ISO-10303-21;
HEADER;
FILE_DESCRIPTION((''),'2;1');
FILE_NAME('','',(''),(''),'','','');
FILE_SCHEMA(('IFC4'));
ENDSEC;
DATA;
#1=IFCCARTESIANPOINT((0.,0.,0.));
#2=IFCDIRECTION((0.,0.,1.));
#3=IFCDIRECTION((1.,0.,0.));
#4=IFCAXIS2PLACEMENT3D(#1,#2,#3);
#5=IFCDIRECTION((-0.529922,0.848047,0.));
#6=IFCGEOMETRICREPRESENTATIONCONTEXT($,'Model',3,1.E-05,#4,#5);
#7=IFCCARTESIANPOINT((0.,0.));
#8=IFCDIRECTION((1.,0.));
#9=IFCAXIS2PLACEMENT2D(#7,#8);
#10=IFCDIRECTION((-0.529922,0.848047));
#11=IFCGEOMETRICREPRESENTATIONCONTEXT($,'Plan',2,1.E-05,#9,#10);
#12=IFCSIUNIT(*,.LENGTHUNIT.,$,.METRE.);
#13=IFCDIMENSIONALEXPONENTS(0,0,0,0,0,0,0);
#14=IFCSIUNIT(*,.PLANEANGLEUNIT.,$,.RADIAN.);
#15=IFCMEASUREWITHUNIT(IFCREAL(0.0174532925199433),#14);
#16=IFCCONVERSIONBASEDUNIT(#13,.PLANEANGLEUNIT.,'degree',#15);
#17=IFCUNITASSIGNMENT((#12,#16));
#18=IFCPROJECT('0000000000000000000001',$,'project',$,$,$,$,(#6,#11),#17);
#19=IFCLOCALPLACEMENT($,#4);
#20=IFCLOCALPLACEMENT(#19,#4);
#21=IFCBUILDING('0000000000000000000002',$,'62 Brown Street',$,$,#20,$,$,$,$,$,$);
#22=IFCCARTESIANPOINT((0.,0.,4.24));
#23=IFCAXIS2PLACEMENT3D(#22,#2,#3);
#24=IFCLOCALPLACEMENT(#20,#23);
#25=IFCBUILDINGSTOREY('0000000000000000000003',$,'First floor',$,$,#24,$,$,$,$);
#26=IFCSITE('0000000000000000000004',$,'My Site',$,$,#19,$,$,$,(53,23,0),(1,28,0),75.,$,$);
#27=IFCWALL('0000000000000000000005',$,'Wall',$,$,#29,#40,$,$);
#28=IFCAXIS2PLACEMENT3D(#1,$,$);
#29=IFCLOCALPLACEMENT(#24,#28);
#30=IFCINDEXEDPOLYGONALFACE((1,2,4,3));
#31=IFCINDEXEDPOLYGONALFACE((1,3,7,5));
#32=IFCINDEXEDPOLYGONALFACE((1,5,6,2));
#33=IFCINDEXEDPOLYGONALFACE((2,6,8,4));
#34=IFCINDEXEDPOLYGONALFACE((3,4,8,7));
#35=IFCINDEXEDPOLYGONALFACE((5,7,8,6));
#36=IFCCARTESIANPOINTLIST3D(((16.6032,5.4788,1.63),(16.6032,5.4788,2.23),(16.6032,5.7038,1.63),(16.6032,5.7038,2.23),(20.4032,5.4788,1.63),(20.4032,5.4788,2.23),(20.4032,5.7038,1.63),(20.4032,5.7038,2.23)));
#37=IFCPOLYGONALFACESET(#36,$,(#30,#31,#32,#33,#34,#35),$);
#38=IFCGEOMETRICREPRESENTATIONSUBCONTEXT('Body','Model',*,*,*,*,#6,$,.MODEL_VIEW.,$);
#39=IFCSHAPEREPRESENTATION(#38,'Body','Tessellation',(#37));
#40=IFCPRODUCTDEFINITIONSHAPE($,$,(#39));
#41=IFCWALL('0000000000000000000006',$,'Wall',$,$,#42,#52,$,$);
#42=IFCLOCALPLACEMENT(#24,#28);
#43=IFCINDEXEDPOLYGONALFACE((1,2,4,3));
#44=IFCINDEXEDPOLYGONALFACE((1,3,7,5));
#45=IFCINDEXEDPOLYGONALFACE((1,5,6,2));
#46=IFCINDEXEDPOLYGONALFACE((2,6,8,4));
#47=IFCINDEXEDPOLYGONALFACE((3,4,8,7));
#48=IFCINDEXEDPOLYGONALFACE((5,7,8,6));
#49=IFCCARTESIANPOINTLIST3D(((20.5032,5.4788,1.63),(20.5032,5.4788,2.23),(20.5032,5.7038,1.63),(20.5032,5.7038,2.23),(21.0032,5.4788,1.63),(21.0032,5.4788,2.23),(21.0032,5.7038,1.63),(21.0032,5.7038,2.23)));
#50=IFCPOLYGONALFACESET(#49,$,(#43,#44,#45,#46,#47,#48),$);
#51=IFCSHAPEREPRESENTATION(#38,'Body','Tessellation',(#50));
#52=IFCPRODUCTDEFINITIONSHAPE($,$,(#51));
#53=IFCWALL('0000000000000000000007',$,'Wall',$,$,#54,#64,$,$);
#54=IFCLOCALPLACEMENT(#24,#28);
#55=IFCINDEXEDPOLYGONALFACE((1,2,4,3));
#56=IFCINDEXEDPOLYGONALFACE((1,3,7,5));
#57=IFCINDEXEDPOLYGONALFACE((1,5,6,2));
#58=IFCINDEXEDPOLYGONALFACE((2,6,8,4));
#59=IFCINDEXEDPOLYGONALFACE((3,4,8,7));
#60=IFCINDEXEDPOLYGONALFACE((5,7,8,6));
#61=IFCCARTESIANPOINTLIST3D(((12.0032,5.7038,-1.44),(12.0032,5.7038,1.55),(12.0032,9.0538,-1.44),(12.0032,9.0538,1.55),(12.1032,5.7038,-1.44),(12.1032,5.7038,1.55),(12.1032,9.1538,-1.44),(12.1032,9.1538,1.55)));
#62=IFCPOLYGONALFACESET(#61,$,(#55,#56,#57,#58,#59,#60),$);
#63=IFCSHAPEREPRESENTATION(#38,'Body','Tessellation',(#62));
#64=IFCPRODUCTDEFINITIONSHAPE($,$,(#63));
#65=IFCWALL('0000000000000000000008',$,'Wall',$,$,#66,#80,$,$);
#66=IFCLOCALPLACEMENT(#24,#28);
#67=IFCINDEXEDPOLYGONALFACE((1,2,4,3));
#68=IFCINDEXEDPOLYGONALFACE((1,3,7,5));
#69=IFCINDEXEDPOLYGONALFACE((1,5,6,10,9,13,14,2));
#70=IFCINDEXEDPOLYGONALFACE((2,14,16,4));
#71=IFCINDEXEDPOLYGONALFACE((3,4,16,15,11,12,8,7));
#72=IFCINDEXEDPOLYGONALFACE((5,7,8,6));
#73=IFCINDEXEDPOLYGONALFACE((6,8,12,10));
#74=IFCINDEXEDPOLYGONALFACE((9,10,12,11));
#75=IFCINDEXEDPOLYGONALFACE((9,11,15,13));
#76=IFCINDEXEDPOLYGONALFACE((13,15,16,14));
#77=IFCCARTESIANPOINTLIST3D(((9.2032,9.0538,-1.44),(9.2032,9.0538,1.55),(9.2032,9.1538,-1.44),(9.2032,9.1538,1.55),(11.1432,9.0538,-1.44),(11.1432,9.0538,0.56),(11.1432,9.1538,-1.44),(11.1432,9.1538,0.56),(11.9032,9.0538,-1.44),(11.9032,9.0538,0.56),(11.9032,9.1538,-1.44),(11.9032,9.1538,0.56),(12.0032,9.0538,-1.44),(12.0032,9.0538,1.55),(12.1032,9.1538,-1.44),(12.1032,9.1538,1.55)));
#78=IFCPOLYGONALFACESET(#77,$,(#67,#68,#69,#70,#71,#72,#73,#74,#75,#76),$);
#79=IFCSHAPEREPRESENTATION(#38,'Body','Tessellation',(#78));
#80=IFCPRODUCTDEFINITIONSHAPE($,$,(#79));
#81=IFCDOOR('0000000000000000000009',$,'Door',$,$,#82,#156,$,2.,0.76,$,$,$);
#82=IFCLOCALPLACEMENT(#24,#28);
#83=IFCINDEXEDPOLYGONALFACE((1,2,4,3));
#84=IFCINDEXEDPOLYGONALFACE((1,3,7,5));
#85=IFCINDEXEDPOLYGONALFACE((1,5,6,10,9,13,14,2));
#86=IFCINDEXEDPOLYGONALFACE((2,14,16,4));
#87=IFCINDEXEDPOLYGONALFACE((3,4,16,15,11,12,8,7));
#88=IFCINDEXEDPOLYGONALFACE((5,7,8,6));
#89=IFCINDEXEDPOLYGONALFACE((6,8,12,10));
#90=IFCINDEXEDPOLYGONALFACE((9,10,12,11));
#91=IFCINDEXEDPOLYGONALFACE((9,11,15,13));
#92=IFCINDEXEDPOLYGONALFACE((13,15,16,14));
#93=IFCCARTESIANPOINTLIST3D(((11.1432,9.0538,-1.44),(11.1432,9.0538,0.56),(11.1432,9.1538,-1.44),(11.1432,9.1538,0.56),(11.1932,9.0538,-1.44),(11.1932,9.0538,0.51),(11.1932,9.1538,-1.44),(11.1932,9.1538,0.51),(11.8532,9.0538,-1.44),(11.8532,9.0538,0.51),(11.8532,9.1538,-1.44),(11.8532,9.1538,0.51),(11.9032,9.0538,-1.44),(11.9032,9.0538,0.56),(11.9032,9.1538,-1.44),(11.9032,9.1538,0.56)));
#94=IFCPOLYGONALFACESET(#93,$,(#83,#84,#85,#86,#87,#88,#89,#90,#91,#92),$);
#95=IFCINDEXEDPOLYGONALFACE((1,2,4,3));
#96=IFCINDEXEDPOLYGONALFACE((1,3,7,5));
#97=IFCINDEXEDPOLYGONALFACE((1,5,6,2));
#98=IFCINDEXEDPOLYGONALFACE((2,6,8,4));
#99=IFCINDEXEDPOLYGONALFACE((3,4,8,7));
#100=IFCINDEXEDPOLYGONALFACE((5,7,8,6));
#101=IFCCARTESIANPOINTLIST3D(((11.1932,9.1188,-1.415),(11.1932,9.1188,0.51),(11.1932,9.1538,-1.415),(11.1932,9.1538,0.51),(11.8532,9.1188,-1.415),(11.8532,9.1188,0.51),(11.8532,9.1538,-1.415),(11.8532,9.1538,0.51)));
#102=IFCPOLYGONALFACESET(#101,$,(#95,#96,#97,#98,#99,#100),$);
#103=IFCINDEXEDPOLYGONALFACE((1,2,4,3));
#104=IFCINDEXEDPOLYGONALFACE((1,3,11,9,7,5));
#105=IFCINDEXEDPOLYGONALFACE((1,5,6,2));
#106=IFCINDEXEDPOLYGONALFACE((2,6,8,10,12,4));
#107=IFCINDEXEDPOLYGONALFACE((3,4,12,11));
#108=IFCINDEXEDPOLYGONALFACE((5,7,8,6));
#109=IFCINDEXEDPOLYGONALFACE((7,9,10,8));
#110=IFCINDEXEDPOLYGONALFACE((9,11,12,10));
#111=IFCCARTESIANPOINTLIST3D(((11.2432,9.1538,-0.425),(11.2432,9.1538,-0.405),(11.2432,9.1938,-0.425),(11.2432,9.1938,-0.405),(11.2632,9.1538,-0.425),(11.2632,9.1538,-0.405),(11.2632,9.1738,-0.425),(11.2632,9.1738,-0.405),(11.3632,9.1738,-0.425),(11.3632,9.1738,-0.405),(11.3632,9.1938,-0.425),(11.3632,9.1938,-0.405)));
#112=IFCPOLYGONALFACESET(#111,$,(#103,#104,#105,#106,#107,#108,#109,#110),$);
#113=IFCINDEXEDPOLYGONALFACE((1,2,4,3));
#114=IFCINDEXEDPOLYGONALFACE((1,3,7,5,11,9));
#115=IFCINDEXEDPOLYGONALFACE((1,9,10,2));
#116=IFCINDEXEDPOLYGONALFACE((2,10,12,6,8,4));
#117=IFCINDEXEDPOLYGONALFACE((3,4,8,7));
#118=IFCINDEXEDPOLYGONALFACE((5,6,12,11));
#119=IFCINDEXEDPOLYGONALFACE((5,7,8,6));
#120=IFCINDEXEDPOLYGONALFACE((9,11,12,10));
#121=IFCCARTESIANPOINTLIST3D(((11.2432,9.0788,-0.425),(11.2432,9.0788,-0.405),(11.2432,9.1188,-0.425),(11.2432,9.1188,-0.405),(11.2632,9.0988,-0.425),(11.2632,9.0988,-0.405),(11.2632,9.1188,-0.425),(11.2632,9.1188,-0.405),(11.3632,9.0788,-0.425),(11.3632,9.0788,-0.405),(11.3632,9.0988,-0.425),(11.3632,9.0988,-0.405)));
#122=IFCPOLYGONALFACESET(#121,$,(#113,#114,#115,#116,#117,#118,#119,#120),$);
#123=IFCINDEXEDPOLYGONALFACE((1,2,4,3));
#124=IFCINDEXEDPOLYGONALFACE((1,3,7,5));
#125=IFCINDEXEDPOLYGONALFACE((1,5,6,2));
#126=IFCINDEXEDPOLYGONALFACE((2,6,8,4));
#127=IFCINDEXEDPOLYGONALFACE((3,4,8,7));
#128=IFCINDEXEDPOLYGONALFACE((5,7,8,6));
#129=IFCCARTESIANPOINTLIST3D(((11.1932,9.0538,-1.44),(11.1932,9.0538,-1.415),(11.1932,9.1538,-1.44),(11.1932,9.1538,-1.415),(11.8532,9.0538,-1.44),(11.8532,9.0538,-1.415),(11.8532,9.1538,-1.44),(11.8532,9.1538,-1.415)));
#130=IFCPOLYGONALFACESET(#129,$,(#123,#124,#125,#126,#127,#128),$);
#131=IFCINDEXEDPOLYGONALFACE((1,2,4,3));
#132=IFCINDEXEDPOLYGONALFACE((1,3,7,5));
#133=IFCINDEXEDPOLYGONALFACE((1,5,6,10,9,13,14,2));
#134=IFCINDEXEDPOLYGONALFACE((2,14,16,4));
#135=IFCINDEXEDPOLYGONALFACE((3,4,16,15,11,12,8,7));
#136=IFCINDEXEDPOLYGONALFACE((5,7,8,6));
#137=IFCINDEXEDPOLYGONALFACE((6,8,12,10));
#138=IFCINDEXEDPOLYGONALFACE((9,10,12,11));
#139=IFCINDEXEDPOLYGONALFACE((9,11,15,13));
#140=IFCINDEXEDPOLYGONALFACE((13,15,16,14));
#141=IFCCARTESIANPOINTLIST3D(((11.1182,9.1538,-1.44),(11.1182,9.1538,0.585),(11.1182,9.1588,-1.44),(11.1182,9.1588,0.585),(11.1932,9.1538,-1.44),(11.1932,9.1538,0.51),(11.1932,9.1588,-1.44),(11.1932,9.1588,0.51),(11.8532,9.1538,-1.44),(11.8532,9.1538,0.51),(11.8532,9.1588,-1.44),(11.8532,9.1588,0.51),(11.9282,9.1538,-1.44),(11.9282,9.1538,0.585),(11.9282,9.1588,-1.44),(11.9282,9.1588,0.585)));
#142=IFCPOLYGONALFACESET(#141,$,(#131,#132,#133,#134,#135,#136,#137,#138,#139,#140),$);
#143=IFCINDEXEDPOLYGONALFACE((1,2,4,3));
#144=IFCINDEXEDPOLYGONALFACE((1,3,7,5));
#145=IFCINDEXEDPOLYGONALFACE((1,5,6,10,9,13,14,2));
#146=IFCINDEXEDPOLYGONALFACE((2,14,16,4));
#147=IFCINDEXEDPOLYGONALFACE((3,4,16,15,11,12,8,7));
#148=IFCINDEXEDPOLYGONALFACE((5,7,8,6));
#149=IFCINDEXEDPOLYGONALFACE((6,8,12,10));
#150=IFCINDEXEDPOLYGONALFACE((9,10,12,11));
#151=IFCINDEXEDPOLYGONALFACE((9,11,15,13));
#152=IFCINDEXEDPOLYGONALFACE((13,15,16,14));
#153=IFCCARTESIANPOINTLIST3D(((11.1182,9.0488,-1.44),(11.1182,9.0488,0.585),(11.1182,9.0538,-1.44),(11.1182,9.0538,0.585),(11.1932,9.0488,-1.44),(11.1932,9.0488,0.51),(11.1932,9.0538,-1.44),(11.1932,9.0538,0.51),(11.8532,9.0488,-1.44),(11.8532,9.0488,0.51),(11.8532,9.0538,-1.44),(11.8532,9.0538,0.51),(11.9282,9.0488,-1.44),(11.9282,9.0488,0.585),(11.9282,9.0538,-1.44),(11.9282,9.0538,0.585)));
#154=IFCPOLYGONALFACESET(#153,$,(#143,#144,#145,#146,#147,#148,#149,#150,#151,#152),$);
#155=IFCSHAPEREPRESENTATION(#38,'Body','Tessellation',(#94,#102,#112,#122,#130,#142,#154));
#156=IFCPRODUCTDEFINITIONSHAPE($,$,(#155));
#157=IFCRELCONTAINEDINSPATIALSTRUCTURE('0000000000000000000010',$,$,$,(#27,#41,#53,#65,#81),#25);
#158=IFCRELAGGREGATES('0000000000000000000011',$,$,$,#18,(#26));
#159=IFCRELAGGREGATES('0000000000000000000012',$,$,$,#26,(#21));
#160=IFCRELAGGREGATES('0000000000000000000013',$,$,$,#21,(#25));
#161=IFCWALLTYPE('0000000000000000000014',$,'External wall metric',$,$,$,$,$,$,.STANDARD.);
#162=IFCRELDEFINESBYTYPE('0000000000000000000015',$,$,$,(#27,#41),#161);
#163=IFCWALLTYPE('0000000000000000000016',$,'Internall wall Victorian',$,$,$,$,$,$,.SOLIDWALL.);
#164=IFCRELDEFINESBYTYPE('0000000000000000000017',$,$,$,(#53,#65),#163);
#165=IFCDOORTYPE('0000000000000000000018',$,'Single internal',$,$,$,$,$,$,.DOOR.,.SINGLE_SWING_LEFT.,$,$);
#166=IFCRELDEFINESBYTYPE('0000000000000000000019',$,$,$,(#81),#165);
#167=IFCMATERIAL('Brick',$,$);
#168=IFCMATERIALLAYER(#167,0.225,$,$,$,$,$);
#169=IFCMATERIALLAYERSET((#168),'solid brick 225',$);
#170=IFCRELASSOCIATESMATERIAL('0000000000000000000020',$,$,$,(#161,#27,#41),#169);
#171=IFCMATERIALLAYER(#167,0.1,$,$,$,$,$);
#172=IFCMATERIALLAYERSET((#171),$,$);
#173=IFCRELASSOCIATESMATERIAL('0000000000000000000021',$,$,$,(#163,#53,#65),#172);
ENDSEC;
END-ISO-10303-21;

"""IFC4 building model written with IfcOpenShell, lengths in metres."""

from ifc_helpers import new_model, entity, si_unit, converted_unit, direction, frame, origin_with_axes, origin_2d_with_axis, place, context, subcontext, project, spatial, line, indexed_curve, outline, extrude, clip, halfspace, shape, source, transform, mapped, material, layer, layer_set, layer_usage, type_object, type_shapes, element, fill, save


model = new_model("IFC4")

# Units and contexts
model_context = context("Model", 3, precision=1e-05, world=origin_with_axes(), true_north=direction((-0.529922, 0.848047, 0.0)))
plan_context = context("Plan", 2, precision=1e-05, world=origin_2d_with_axis(), true_north=direction((-0.529922, 0.848047)))
body_context_1 = subcontext(model_context, "Body", "Model", "MODEL_VIEW")
body_context_2 = subcontext(plan_context, "Body", "Plan", "PLAN_VIEW")
ifc_project = project(units=[si_unit("LENGTHUNIT", "METRE"), converted_unit("PLANEANGLEUNIT", "degree", entity("IfcReal", 0.0174532925199433), si_unit("PLANEANGLEUNIT", "RADIAN"), dimensions=[0, 0, 0, 0, 0, 0, 0])], contexts=[model_context, plan_context])

# Site, building, storey
site_placement = place(None, origin_with_axes())
site = spatial("IfcSite", under=ifc_project, at=site_placement, Name="My Site", RefLatitude=(53, 23, 0), RefLongitude=(1, 28, 0), RefElevation=75.0)
building_placement = place(site_placement, origin_with_axes())
building = spatial("IfcBuilding", under=site, at=building_placement, Name="62 Brown Street")
storey_placement = place(building_placement, frame((0.0, 0.0, 4.24), z_axis=(0.0, 0.0, 1.0), x_axis=(1.0, 0.0, 0.0)))
storey = spatial("IfcBuildingStorey", under=building, at=storey_placement, Name="First floor")

# Walls
ifc_material_1 = material(Name="Brick")
ifc_layer_1 = layer(ifc_material_1, 0.225)
ifc_layer_set_1 = layer_set([ifc_layer_1], Name="solid brick 225")
wall_type_1 = type_object("IfcWallType", Name="External wall metric", PredefinedType="STANDARD", material=ifc_layer_set_1)
ifc_layer_usage_1 = layer_usage(ifc_layer_set_1, "AXIS2", "POSITIVE", 0.0)
wall_1_placement = place(storey_placement, frame((16.6032, 5.4788, 1.63), z_axis=(0.0, 0.0, 1.0), x_axis=(1.0, 0.0, 0.0)))
element("IfcWall", 1, at=wall_1_placement, inside=storey, type_object=wall_type_1, material=ifc_layer_usage_1, Name="Wall", context=body_context_1, shape_type="SweptSolid", body=[
    extrude(outline(indexed_curve([(0.0, 0.0), (0.0, 0.225), (3.8, 0.225), (3.8, 0.0), (0.0, 0.0)], self_intersect=False)), origin_with_axes(), (0.0, 0.0, 1.0), 0.6),
])
ifc_layer_usage_2 = layer_usage(ifc_layer_set_1, "AXIS2", "POSITIVE", 0.0)
wall_2_placement = place(storey_placement, frame((20.5032, 5.4788, 1.63), z_axis=(0.0, 0.0, 1.0), x_axis=(1.0, 0.0, 0.0)))
element("IfcWall", 2, at=wall_2_placement, inside=storey, type_object=wall_type_1, material=ifc_layer_usage_2, Name="Wall", context=body_context_1, shape_type="SweptSolid", body=[
    extrude(outline(indexed_curve([(0.0, 0.0), (0.0, 0.225), (0.5, 0.225), (0.5, 0.0), (0.0, 0.0)], self_intersect=False)), origin_with_axes(), (0.0, 0.0, 1.0), 0.6),
])
ifc_layer_2 = layer(ifc_material_1, 0.1)
ifc_layer_set_2 = layer_set([ifc_layer_2])
ifc_layer_usage_3 = layer_usage(ifc_layer_set_2, "AXIS2", "POSITIVE", 0.0)
wall_type_2 = type_object("IfcWallType", Name="Internall wall Victorian", PredefinedType="SOLIDWALL", material=ifc_layer_set_2)
wall_3_placement = place(storey_placement, frame((12.1032, 5.7038, -1.44), z_axis=(0.0, 0.0, 1.0), x_axis=(0.0, 1.0, 0.0)))
element("IfcWall", 3, at=wall_3_placement, inside=storey, type_object=wall_type_2, material=ifc_layer_usage_3, Name="Wall", context=body_context_1, shape_type="Clipping", body=[
    clip(extrude(outline(indexed_curve([(0.0, 0.0), (0.0, 0.1), (3.45, 0.1), (3.45, 0.0), (0.0, 0.0)], self_intersect=False)), origin_with_axes(), (0.0, 0.0, 1.0), 2.99), halfspace(frame((3.45, 0.0, -2.8), z_axis=(0.707107, 0.707107, 0.0), x_axis=(0.707107, -0.707107, 0.0)), False)),
])

# Wall, opening, door
ifc_layer_usage_4 = layer_usage(ifc_layer_set_2, "AXIS2", "POSITIVE", 0.0)
wall_4_placement = place(storey_placement, frame((12.1032, 9.1538, -1.44), z_axis=(0.0, 0.0, 1.0), x_axis=(-1.0, 0.0, 0.0)))
wall_4 = element("IfcWall", 4, at=wall_4_placement, inside=storey, type_object=wall_type_2, material=ifc_layer_usage_4, Name="Wall", context=body_context_1, shape_type="Clipping", body=[
    clip(extrude(outline(indexed_curve([(0.0, 0.0), (0.0, 0.1), (2.9, 0.1), (2.9, 0.0), (0.0, 0.0)], self_intersect=False)), origin_with_axes(), (0.0, 0.0, 1.0), 2.99), halfspace(frame((0.0, 0.0, -2.8), z_axis=(-0.299001, 0.299001, 0.0), x_axis=(0.1, 0.1, 0.0)), False)),
])
shared_shape_1 = source(origin_with_axes(), body_context_1, "Body", "SweptSolid", [
    extrude(outline(indexed_curve([(0.0, 0.0), (0.76, 0.0), (0.76, 2.0), (0.0, 2.0)], segments=[line(1, 2, 3, 4, 1)])), frame((0.0, -0.6, 0.0), z_axis=(0.0, -1.0, 0.0), x_axis=(1.0, 0.0, 0.0)), (0.0, 0.0, -1.0), 1.2),
])
opening_placement = place(wall_4_placement, frame((0.2, 0.0, 0.0), z_axis=(0.0, 0.0, 1.0), x_axis=(1.0, 0.0, 0.0)))
opening = element("IfcOpeningElement", 5, at=opening_placement, cuts=wall_4, PredefinedType="OPENING", context=body_context_1, shape_type="MappedRepresentation", body=[
    mapped(shared_shape_1, transform((0.0, 0.0, 0.0), x_axis=(1.0, 0.0, 0.0), y_axis=(0.0, 1.0, 0.0), z_axis=(0.0, 0.0, 1.0), scale=1.0)),
])
door_type = type_object("IfcDoorType", Name="Single internal", OperationType="SINGLE_SWING_LEFT", PredefinedType="DOOR")
shared_shape_2 = source(origin_with_axes(), body_context_1, "Body", "SweptSolid", [
    extrude(outline(indexed_curve([(0.0, 0.0), (0.0, 2.0), (0.76, 2.0), (0.76, 0.0), (0.71, 0.0), (0.71, 1.95), (0.05, 1.95), (0.05, 0.0)], segments=[line(1, 2, 3, 4, 5, 6, 7, 8, 1)])), frame((0.0, 0.0, 0.0), z_axis=(0.0, -1.0, 0.0), x_axis=(1.0, 0.0, 0.0)), (0.0, 0.0, -1.0), 0.1),
    extrude(outline(indexed_curve([(0.0, 0.0), (0.66, 0.0), (0.66, 0.035), (0.0, 0.035)], segments=[line(1, 2, 3, 4, 1)])), frame((0.05, 0.0, 0.025), z_axis=(0.0, 0.0, 1.0), x_axis=(1.0, 0.0, 0.0)), (0.0, 0.0, 1.0), 1.925),
    extrude(outline(indexed_curve([(0.0, 0.0), (0.0, -0.04), (-0.12, -0.04), (-0.12, -0.02), (-0.02, -0.02), (-0.02, 0.0)], segments=[line(1, 2, 3, 4, 5, 6, 1)])), frame((0.66, 0.0, 1.015), z_axis=(0.0, 0.0, 1.0), x_axis=(1.0, 0.0, 0.0)), (0.0, 0.0, 1.0), 0.02),
    extrude(outline(indexed_curve([(0.0, 0.0), (0.0, 0.04), (-0.12, 0.04), (-0.12, 0.02), (-0.02, 0.02), (-0.02, 0.0)], segments=[line(1, 2, 3, 4, 5, 6, 1)])), frame((0.66, 0.035, 1.015), z_axis=(0.0, 0.0, 1.0), x_axis=(1.0, 0.0, 0.0)), (0.0, 0.0, 1.0), 0.02),
    extrude(outline(indexed_curve([(0.0, 0.0), (0.66, 0.0), (0.66, 0.1), (0.0, 0.1)], segments=[line(1, 2, 3, 4, 1)])), frame((0.05, 0.0, 0.0), z_axis=(0.0, 0.0, 1.0), x_axis=(1.0, 0.0, 0.0)), (0.0, 0.0, 1.0), 0.025),
    extrude(outline(indexed_curve([(0.0, 0.0), (0.0, 2.025), (0.81, 2.025), (0.81, 0.0), (0.735, 0.0), (0.735, 1.95), (0.075, 1.95), (0.075, 0.0)], segments=[line(1, 2, 3, 4, 5, 6, 7, 8, 1)])), frame((-0.025, -0.005, 0.0), z_axis=(0.0, -1.0, 0.0), x_axis=(1.0, 0.0, 0.0)), (0.0, 0.0, -1.0), 0.005),
    extrude(outline(indexed_curve([(0.0, 0.0), (0.0, 2.025), (0.81, 2.025), (0.81, 0.0), (0.735, 0.0), (0.735, 1.95), (0.075, 1.95), (0.075, 0.0)], segments=[line(1, 2, 3, 4, 5, 6, 7, 8, 1)])), frame((-0.025, 0.1, 0.0), z_axis=(0.0, -1.0, 0.0), x_axis=(1.0, 0.0, 0.0)), (0.0, 0.0, -1.0), 0.005),
])
shared_shape_3 = source(origin_with_axes(), body_context_2, "Body", "Curve2D", [
    entity("IfcIndexedPolyCurve", entity("IfcCartesianPointList2D", [[0.0, 0.0], [0.05, 0.0], [0.05, 0.1], [0.0, 0.1]]), [entity("IfcLineIndex", [1, 2, 3, 4, 1])]),
    entity("IfcIndexedPolyCurve", entity("IfcCartesianPointList2D", [[0.76, 0.0], [0.71, 0.0], [0.71, 0.1], [0.76, 0.1]]), [entity("IfcLineIndex", [1, 2, 3, 4, 1])]),
    entity("IfcTrimmedCurve", entity("IfcEllipse", entity("IfcAxis2Placement2D", entity("IfcCartesianPoint", [0.085, 0.1]), entity("IfcDirection", [1.0, 0.0])), 0.625, 0.66), [entity("IfcCartesianPoint", [0.71, 0.1])], [entity("IfcCartesianPoint", [0.085, 0.76])], True, "CARTESIAN"),
    entity("IfcIndexedPolyCurve", entity("IfcCartesianPointList2D", [[0.05, 0.1], [0.085, 0.1], [0.085, 0.76], [0.05, 0.76]]), [entity("IfcLineIndex", [1, 2, 3, 4, 1])]),
])
type_shapes(door_type, [shared_shape_2, shared_shape_3])
door_placement = place(opening_placement, frame((0.0, 0.0, 0.0), z_axis=(0.0, 0.0, 1.0), x_axis=(1.0, 0.0, 0.0)))
door = element("IfcDoor", 6, at=door_placement, inside=storey, type_object=door_type, Name="Door", OverallHeight=2.0, OverallWidth=0.76, shapes=[
    shape(body_context_1, "Body", "MappedRepresentation", [mapped(shared_shape_2, transform((0.0, 0.0, 0.0), x_axis=(1.0, 0.0, 0.0), y_axis=(0.0, 1.0, 0.0), z_axis=(0.0, 0.0, 1.0), scale=1.0))]),
    shape(body_context_2, "Body", "MappedRepresentation", [mapped(shared_shape_3, transform((0.0, 0.0, 0.0), x_axis=(1.0, 0.0, 0.0), y_axis=(0.0, 1.0, 0.0), z_axis=(0.0, 0.0, 1.0), scale=1.0))]),
])
fill(opening, door)

save(model, "model.ifc")
